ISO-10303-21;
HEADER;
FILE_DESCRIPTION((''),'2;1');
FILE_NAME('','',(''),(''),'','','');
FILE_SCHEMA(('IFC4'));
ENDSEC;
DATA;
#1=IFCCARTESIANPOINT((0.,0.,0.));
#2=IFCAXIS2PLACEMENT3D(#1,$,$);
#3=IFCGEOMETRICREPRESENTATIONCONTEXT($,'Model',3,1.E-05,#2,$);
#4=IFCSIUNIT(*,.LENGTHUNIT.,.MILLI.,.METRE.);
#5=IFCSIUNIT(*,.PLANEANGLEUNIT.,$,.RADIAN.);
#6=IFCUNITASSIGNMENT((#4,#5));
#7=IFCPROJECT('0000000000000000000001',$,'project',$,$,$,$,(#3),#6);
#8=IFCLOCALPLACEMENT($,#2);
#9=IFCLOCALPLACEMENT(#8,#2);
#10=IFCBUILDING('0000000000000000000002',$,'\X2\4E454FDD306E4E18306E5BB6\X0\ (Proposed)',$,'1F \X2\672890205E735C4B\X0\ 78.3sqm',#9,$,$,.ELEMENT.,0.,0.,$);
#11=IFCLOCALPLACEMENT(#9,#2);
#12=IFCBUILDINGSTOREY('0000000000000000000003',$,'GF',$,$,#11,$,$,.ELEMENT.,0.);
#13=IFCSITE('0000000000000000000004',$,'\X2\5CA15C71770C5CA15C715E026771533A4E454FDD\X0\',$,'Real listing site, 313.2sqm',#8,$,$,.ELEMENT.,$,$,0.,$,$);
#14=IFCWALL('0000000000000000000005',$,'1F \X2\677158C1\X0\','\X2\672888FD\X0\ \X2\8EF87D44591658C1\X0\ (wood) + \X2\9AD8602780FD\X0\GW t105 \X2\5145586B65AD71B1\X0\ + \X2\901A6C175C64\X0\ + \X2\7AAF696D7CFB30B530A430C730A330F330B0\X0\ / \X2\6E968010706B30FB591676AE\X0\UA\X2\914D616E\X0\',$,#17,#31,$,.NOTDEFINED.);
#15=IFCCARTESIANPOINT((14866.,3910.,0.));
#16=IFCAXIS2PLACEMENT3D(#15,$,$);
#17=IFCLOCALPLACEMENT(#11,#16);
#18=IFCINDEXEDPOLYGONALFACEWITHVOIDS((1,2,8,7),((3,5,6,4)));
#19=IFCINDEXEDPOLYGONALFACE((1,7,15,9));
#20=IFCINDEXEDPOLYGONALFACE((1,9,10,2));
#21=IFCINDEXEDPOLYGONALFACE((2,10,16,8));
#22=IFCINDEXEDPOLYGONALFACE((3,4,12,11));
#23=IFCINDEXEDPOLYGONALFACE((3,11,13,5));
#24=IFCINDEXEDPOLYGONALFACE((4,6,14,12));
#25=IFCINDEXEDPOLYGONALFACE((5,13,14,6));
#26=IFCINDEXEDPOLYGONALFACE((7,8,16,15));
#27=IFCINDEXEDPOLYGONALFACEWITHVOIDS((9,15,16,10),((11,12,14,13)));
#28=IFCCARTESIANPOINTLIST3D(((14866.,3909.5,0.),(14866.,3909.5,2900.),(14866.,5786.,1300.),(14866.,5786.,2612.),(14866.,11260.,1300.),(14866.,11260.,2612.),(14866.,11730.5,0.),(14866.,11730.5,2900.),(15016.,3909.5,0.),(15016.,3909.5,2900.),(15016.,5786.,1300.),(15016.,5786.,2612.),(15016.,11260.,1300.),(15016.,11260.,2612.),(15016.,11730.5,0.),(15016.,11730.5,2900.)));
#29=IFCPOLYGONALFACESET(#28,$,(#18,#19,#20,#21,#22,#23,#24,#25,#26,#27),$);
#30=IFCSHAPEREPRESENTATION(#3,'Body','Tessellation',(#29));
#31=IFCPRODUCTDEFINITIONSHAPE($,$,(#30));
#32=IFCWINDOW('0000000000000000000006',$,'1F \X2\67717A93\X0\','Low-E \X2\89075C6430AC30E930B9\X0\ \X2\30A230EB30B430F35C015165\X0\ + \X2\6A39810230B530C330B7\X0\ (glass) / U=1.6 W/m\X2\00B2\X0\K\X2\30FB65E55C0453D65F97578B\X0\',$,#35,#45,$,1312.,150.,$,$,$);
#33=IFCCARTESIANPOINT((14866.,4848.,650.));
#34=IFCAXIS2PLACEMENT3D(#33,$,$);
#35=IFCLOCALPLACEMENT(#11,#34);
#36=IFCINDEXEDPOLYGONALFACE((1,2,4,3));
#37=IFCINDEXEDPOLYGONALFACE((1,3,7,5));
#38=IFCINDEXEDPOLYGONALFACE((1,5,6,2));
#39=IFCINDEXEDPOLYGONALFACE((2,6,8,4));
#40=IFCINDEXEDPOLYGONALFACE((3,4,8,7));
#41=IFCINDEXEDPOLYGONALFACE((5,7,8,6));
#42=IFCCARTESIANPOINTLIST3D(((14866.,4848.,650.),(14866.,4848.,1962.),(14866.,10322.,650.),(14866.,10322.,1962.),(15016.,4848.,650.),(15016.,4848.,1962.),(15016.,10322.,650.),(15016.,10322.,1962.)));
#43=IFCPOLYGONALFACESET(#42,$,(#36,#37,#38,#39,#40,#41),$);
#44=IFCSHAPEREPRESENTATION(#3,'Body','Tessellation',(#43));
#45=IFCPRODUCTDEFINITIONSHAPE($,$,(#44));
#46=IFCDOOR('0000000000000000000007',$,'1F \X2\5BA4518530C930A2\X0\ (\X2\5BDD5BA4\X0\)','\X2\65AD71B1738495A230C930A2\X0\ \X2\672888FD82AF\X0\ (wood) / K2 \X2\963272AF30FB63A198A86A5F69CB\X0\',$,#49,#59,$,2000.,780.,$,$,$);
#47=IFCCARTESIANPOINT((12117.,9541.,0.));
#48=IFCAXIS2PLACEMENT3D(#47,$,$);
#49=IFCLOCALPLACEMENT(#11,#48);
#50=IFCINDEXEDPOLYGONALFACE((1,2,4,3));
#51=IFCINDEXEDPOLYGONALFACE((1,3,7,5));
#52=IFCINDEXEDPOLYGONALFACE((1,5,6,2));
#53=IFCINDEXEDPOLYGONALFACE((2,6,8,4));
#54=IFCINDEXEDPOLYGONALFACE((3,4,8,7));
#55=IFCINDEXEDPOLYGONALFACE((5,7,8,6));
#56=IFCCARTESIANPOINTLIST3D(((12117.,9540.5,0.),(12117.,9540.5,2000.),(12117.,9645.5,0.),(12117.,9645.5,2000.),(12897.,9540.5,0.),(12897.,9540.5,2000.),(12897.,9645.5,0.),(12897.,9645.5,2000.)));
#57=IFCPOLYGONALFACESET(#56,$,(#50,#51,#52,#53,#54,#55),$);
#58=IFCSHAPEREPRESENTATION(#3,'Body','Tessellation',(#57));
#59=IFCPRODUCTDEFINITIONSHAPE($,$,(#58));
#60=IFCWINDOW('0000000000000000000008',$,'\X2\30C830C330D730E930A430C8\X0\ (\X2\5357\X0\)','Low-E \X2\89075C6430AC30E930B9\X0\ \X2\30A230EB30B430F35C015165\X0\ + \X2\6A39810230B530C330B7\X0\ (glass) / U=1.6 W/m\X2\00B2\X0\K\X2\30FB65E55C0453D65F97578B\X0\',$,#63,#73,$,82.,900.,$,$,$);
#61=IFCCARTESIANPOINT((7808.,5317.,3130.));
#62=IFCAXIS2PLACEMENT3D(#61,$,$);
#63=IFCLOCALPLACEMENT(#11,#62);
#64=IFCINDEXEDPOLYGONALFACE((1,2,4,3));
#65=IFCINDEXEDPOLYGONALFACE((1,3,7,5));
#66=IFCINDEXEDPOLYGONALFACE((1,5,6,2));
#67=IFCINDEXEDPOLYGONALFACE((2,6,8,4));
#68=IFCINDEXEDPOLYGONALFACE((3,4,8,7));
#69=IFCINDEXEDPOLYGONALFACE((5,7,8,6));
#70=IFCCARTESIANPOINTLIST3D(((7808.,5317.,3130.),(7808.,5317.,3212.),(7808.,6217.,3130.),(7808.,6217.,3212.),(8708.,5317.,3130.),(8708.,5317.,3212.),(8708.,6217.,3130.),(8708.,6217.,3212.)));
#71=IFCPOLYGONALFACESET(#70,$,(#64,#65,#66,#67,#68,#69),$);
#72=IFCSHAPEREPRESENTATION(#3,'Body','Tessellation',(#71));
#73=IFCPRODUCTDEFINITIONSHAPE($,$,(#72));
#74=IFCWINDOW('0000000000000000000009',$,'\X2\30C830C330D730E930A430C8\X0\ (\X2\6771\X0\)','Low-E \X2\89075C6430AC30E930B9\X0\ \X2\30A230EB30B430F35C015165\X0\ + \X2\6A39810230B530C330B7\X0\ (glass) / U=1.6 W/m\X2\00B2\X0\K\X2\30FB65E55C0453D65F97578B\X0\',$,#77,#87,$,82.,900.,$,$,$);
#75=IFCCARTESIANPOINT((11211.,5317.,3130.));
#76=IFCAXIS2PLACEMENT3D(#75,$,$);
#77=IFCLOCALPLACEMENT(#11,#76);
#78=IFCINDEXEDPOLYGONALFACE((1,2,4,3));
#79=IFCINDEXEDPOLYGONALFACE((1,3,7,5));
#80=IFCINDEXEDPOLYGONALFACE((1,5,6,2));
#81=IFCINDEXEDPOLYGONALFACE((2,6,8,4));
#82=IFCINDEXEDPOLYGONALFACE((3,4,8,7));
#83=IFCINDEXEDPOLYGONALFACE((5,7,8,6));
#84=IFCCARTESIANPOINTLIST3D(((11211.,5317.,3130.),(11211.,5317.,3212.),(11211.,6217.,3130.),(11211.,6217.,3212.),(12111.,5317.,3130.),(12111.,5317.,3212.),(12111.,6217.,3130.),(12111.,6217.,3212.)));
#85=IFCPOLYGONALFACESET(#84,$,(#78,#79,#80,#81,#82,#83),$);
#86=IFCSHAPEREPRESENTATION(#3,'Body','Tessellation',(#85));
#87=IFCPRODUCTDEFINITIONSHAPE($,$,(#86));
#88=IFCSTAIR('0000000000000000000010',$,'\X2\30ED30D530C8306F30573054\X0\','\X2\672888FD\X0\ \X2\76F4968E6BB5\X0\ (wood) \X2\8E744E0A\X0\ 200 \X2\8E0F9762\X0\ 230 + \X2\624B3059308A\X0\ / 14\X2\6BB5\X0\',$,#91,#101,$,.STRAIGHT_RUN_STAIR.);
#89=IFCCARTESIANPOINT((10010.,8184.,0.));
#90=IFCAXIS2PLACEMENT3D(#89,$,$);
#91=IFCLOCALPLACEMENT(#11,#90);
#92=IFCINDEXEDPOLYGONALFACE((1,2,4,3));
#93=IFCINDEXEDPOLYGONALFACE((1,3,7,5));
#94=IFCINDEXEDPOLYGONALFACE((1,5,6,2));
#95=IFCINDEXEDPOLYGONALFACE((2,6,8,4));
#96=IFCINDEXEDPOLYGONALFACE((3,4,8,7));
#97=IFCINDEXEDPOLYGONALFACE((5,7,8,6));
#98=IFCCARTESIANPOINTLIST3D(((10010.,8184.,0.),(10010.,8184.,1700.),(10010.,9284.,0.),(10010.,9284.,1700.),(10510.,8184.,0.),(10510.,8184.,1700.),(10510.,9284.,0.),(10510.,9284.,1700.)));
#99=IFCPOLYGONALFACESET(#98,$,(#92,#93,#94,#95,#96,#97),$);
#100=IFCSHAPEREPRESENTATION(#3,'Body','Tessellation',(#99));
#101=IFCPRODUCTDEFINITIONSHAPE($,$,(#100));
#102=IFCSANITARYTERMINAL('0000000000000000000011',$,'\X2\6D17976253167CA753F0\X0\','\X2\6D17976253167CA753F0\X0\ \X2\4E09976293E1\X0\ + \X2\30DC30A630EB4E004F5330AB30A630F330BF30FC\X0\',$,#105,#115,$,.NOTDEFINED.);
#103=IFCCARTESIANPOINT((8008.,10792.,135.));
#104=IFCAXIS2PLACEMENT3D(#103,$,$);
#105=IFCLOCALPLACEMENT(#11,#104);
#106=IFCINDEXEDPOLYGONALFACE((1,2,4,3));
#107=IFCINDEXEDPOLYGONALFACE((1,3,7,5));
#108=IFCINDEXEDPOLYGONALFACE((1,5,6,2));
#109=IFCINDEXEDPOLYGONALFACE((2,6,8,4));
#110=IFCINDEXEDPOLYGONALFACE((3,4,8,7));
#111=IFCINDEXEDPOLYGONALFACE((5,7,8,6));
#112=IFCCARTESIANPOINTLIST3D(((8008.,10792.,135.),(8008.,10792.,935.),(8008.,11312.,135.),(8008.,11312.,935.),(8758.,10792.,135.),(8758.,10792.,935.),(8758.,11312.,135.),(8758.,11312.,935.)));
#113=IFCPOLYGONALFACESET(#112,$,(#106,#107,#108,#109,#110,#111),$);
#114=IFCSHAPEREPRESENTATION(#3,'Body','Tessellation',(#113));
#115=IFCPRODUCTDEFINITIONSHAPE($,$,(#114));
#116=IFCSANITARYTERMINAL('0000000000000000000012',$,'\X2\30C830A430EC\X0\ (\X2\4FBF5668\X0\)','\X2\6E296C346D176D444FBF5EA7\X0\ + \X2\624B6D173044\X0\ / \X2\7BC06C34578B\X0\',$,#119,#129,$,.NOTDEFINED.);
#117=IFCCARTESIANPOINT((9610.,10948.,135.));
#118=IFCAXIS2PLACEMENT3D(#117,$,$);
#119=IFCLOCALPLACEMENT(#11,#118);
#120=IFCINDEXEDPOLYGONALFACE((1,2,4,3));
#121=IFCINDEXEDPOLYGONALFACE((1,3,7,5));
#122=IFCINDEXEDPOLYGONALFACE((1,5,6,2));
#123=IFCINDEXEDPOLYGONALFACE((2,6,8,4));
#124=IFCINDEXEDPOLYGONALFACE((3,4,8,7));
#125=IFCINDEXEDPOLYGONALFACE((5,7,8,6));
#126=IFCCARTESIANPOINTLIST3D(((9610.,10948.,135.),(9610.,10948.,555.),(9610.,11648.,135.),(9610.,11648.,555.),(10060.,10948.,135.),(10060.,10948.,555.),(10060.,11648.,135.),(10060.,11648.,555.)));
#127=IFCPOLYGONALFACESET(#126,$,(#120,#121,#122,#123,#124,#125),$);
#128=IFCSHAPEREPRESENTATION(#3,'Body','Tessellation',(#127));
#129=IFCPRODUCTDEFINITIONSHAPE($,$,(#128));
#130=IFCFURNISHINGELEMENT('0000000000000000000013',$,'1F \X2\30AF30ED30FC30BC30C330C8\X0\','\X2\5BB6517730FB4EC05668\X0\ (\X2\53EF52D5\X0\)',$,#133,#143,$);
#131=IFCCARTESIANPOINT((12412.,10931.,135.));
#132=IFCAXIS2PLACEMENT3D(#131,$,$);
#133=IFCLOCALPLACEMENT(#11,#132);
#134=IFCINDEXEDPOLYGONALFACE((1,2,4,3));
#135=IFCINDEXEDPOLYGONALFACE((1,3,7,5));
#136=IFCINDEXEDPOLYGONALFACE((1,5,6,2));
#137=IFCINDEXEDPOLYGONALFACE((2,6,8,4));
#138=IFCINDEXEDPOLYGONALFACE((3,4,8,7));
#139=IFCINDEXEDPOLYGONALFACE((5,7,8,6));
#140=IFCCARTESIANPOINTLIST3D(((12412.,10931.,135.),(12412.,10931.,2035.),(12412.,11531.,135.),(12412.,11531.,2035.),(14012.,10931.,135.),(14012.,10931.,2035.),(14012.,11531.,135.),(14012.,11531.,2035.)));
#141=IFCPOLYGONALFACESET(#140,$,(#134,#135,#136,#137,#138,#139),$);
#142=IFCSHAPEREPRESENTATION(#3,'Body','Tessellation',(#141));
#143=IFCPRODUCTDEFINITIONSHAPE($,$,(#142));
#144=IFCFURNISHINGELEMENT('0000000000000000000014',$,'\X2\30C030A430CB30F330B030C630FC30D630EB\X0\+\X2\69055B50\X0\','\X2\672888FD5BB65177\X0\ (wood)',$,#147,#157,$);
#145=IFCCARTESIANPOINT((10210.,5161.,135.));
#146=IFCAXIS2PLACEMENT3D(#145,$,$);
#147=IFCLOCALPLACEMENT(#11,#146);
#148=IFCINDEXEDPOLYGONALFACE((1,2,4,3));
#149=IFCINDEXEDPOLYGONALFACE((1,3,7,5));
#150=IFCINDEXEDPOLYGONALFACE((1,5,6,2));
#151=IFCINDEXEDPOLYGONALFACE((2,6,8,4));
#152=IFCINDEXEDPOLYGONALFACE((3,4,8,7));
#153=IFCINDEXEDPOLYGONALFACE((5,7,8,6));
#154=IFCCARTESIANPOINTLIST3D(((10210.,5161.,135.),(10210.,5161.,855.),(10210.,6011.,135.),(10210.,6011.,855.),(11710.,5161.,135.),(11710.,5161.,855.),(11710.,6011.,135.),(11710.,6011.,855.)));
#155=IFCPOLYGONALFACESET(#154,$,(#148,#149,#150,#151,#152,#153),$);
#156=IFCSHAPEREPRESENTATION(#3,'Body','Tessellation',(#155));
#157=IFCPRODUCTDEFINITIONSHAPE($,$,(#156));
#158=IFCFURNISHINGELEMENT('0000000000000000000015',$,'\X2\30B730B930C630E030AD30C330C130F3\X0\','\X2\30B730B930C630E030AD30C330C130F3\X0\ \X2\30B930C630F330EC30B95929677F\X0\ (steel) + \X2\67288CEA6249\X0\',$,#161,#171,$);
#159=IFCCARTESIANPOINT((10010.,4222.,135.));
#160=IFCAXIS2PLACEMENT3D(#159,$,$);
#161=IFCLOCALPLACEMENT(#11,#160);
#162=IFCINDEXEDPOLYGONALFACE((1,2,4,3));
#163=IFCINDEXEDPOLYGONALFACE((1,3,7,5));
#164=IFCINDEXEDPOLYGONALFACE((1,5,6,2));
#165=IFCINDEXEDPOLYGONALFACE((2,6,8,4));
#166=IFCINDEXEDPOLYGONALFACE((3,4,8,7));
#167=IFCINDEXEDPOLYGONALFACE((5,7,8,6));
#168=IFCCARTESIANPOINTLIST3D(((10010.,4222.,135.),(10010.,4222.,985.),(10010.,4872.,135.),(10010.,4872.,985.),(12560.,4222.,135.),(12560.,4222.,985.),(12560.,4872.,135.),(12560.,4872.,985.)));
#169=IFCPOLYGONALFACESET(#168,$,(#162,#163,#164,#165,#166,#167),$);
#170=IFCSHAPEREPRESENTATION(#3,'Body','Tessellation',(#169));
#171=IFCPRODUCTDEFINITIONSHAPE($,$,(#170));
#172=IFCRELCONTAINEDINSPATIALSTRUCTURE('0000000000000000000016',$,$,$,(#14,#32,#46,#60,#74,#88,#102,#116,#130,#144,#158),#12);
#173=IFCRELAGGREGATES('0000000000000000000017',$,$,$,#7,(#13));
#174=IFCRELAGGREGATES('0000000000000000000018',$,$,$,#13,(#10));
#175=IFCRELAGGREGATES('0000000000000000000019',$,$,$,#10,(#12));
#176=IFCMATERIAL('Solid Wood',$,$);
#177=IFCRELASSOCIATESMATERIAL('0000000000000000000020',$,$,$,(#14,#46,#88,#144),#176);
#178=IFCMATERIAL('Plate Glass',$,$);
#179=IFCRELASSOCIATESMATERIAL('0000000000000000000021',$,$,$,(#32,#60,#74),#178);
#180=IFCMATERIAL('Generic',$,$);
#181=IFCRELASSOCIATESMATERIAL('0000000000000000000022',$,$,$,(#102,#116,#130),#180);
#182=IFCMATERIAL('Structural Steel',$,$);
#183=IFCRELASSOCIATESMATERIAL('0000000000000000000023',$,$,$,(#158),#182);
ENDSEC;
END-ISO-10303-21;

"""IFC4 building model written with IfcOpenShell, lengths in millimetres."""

from ifc_helpers import new_model, si_unit, frame, frame_2d, origin, place, context, project, spatial, rectangle, extrude, material, element, fill, save


model = new_model("IFC4")

# Units and contexts
model_context = context("Model", 3, precision=1e-05, world=origin())
ifc_project = project(units=[si_unit("LENGTHUNIT", "METRE", prefix="MILLI"), si_unit("PLANEANGLEUNIT", "RADIAN")], contexts=[model_context])

# Site, building, storey
site_placement = place(None, origin())
site = spatial("IfcSite", under=ifc_project, at=site_placement, Name="岡山県岡山市東区久保", ObjectType="Real listing site, 313.2sqm", CompositionType="ELEMENT", RefElevation=0.0)
building_placement = place(site_placement, origin())
building = spatial("IfcBuilding", under=site, at=building_placement, Name="久保の丘の家 (Proposed)", ObjectType="1F 木造平屋 78.3sqm", CompositionType="ELEMENT", ElevationOfRefHeight=0.0, ElevationOfTerrain=0.0)
storey_placement = place(building_placement, origin())
storey = spatial("IfcBuildingStorey", under=building, at=storey_placement, Name="GF", CompositionType="ELEMENT", Elevation=0.0)

# Shared definitions
ifc_material_1 = material(Name="Solid Wood")

# Wall, opening, window
wall_1_placement = place(storey_placement, frame((14866.0, 3910.0, 0.0)))
wall_1 = element("IfcWall", 1, at=wall_1_placement, inside=storey, material=ifc_material_1, Name="1F 東壁", Description="木製 軸組外壁 (wood) + 高性能GW t105 充填断熱 + 通気層 + 窯業系サイディング / 準耐火・外皮UA配慮", PredefinedType="NOTDEFINED", context=model_context, shape_type="SweptSolid", body=[
    extrude(rectangle(XDim=150.0, YDim=7821.0, at=frame_2d((75.0, 3910.0))), frame((14866.0, 3910.0, 0.0)), (0.0, 0.0, 1.0), 2900.0),
])
opening_1_placement = place(storey_placement, frame((14866.0, 4848.0, 650.0)))
opening_1 = element("IfcOpeningElement", 2, at=opening_1_placement, cuts=wall_1, PredefinedType="NOTDEFINED", context=model_context, shape_type="SweptSolid", body=[
    extrude(rectangle(XDim=150.0, YDim=5474.0, at=frame_2d((75.0, 2737.0))), frame((14866.0, 4848.0, 650.0)), (0.0, 0.0, 1.0), 1312.0),
])
ifc_material_2 = material(Name="Plate Glass")
window_1_placement = place(storey_placement, frame((14866.0, 4848.0, 650.0)))
window_1 = element("IfcWindow", 3, at=window_1_placement, inside=storey, material=ifc_material_2, Name="1F 東窓", Description="Low-E 複層ガラス アルゴン封入 + 樹脂サッシ (glass) / U=1.6 W/m²K・日射取得型", OverallHeight=1312.0, OverallWidth=150.0, context=model_context, shape_type="SweptSolid", body=[
    extrude(rectangle(XDim=150.0, YDim=5474.0, at=frame_2d((75.0, 2737.0))), frame((14866.0, 4848.0, 650.0)), (0.0, 0.0, 1.0), 1312.0),
])
fill(opening_1, window_1)

# Door
door_placement = place(storey_placement, frame((12117.0, 9541.0, 0.0)))
element("IfcDoor", 4, at=door_placement, inside=storey, material=ifc_material_1, Name="1F 室内ドア (寝室)", Description="断熱玄関ドア 木製芯 (wood) / K2 防犯・採風機構", OverallHeight=2000.0, OverallWidth=780.0, context=model_context, shape_type="SweptSolid", body=[
    extrude(rectangle(XDim=780.0, YDim=105.0, at=frame_2d((390.0, 52.0))), frame((12117.0, 9541.0, 0.0)), (0.0, 0.0, 1.0), 2000.0),
])

# Windows
window_2_placement = place(storey_placement, frame((7808.0, 5317.0, 3130.0)))
element("IfcWindow", 5, at=window_2_placement, inside=storey, material=ifc_material_2, Name="トップライト (南)", Description="Low-E 複層ガラス アルゴン封入 + 樹脂サッシ (glass) / U=1.6 W/m²K・日射取得型", OverallHeight=82.0, OverallWidth=900.0, context=model_context, shape_type="SweptSolid", body=[
    extrude(rectangle(XDim=900.0, YDim=900.0, at=frame_2d((450.0, 450.0))), frame((7808.0, 5317.0, 3130.0)), (0.0, 0.0, 1.0), 82.0),
])
window_3_placement = place(storey_placement, frame((11211.0, 5317.0, 3130.0)))
element("IfcWindow", 6, at=window_3_placement, inside=storey, material=ifc_material_2, Name="トップライト (東)", Description="Low-E 複層ガラス アルゴン封入 + 樹脂サッシ (glass) / U=1.6 W/m²K・日射取得型", OverallHeight=82.0, OverallWidth=900.0, context=model_context, shape_type="SweptSolid", body=[
    extrude(rectangle(XDim=900.0, YDim=900.0, at=frame_2d((450.0, 450.0))), frame((11211.0, 5317.0, 3130.0)), (0.0, 0.0, 1.0), 82.0),
])

# Stair
stair_placement = place(storey_placement, frame((10010.0, 8184.0, 0.0)))
element("IfcStair", 7, at=stair_placement, inside=storey, material=ifc_material_1, Name="ロフトはしご", Description="木製 直階段 (wood) 蹴上 200 踏面 230 + 手すり / 14段", PredefinedType="STRAIGHT_RUN_STAIR", context=model_context, shape_type="SweptSolid", body=[
    extrude(rectangle(XDim=500.0, YDim=1100.0, at=frame_2d((250.0, 550.0))), frame((10010.0, 8184.0, 0.0)), (0.0, 0.0, 1.0), 1700.0),
])

# Shared definitions
ifc_material_3 = material(Name="Structural Steel")

# Shared definitions
ifc_material_4 = material(Name="Generic")

# Sanitary terminals
sanitary_terminal_1_placement = place(storey_placement, frame((8008.0, 10792.0, 135.0)))
element("IfcSanitaryTerminal", 8, at=sanitary_terminal_1_placement, inside=storey, material=ifc_material_4, Name="洗面化粧台", Description="洗面化粧台 三面鏡 + ボウル一体カウンター", PredefinedType="NOTDEFINED", context=model_context, shape_type="SweptSolid", body=[
    extrude(rectangle(XDim=750.0, YDim=520.0, at=frame_2d((375.0, 260.0))), frame((8008.0, 10792.0, 135.0)), (0.0, 0.0, 1.0), 800.0),
])
sanitary_terminal_2_placement = place(storey_placement, frame((9610.0, 10948.0, 135.0)))
element("IfcSanitaryTerminal", 9, at=sanitary_terminal_2_placement, inside=storey, material=ifc_material_4, Name="トイレ (便器)", Description="温水洗浄便座 + 手洗い / 節水型", PredefinedType="NOTDEFINED", context=model_context, shape_type="SweptSolid", body=[
    extrude(rectangle(XDim=450.0, YDim=700.0, at=frame_2d((225.0, 350.0))), frame((9610.0, 10948.0, 135.0)), (0.0, 0.0, 1.0), 420.0),
])

# Furnishing elements
furnishing_1_placement = place(storey_placement, frame((12412.0, 10931.0, 135.0)))
element("IfcFurnishingElement", 10, at=furnishing_1_placement, inside=storey, material=ifc_material_4, Name="1F クローゼット", Description="家具・什器 (可動)", context=model_context, shape_type="SweptSolid", body=[
    extrude(rectangle(XDim=1600.0, YDim=600.0, at=frame_2d((800.0, 300.0))), frame((12412.0, 10931.0, 135.0)), (0.0, 0.0, 1.0), 1900.0),
])
furnishing_2_placement = place(storey_placement, frame((10210.0, 5161.0, 135.0)))
element("IfcFurnishingElement", 11, at=furnishing_2_placement, inside=storey, material=ifc_material_1, Name="ダイニングテーブル+椅子", Description="木製家具 (wood)", context=model_context, shape_type="SweptSolid", body=[
    extrude(rectangle(XDim=1500.0, YDim=850.0, at=frame_2d((750.0, 425.0))), frame((10210.0, 5161.0, 135.0)), (0.0, 0.0, 1.0), 720.0),
])
furnishing_3_placement = place(storey_placement, frame((10010.0, 4222.0, 135.0)))
element("IfcFurnishingElement", 12, at=furnishing_3_placement, inside=storey, material=ifc_material_3, Name="システムキッチン", Description="システムキッチン ステンレス天板 (steel) + 木質扉", context=model_context, shape_type="SweptSolid", body=[
    extrude(rectangle(XDim=2550.0, YDim=650.0, at=frame_2d((1275.0, 325.0))), frame((10010.0, 4222.0, 135.0)), (0.0, 0.0, 1.0), 850.0),
])

save(model, "model.ifc")
